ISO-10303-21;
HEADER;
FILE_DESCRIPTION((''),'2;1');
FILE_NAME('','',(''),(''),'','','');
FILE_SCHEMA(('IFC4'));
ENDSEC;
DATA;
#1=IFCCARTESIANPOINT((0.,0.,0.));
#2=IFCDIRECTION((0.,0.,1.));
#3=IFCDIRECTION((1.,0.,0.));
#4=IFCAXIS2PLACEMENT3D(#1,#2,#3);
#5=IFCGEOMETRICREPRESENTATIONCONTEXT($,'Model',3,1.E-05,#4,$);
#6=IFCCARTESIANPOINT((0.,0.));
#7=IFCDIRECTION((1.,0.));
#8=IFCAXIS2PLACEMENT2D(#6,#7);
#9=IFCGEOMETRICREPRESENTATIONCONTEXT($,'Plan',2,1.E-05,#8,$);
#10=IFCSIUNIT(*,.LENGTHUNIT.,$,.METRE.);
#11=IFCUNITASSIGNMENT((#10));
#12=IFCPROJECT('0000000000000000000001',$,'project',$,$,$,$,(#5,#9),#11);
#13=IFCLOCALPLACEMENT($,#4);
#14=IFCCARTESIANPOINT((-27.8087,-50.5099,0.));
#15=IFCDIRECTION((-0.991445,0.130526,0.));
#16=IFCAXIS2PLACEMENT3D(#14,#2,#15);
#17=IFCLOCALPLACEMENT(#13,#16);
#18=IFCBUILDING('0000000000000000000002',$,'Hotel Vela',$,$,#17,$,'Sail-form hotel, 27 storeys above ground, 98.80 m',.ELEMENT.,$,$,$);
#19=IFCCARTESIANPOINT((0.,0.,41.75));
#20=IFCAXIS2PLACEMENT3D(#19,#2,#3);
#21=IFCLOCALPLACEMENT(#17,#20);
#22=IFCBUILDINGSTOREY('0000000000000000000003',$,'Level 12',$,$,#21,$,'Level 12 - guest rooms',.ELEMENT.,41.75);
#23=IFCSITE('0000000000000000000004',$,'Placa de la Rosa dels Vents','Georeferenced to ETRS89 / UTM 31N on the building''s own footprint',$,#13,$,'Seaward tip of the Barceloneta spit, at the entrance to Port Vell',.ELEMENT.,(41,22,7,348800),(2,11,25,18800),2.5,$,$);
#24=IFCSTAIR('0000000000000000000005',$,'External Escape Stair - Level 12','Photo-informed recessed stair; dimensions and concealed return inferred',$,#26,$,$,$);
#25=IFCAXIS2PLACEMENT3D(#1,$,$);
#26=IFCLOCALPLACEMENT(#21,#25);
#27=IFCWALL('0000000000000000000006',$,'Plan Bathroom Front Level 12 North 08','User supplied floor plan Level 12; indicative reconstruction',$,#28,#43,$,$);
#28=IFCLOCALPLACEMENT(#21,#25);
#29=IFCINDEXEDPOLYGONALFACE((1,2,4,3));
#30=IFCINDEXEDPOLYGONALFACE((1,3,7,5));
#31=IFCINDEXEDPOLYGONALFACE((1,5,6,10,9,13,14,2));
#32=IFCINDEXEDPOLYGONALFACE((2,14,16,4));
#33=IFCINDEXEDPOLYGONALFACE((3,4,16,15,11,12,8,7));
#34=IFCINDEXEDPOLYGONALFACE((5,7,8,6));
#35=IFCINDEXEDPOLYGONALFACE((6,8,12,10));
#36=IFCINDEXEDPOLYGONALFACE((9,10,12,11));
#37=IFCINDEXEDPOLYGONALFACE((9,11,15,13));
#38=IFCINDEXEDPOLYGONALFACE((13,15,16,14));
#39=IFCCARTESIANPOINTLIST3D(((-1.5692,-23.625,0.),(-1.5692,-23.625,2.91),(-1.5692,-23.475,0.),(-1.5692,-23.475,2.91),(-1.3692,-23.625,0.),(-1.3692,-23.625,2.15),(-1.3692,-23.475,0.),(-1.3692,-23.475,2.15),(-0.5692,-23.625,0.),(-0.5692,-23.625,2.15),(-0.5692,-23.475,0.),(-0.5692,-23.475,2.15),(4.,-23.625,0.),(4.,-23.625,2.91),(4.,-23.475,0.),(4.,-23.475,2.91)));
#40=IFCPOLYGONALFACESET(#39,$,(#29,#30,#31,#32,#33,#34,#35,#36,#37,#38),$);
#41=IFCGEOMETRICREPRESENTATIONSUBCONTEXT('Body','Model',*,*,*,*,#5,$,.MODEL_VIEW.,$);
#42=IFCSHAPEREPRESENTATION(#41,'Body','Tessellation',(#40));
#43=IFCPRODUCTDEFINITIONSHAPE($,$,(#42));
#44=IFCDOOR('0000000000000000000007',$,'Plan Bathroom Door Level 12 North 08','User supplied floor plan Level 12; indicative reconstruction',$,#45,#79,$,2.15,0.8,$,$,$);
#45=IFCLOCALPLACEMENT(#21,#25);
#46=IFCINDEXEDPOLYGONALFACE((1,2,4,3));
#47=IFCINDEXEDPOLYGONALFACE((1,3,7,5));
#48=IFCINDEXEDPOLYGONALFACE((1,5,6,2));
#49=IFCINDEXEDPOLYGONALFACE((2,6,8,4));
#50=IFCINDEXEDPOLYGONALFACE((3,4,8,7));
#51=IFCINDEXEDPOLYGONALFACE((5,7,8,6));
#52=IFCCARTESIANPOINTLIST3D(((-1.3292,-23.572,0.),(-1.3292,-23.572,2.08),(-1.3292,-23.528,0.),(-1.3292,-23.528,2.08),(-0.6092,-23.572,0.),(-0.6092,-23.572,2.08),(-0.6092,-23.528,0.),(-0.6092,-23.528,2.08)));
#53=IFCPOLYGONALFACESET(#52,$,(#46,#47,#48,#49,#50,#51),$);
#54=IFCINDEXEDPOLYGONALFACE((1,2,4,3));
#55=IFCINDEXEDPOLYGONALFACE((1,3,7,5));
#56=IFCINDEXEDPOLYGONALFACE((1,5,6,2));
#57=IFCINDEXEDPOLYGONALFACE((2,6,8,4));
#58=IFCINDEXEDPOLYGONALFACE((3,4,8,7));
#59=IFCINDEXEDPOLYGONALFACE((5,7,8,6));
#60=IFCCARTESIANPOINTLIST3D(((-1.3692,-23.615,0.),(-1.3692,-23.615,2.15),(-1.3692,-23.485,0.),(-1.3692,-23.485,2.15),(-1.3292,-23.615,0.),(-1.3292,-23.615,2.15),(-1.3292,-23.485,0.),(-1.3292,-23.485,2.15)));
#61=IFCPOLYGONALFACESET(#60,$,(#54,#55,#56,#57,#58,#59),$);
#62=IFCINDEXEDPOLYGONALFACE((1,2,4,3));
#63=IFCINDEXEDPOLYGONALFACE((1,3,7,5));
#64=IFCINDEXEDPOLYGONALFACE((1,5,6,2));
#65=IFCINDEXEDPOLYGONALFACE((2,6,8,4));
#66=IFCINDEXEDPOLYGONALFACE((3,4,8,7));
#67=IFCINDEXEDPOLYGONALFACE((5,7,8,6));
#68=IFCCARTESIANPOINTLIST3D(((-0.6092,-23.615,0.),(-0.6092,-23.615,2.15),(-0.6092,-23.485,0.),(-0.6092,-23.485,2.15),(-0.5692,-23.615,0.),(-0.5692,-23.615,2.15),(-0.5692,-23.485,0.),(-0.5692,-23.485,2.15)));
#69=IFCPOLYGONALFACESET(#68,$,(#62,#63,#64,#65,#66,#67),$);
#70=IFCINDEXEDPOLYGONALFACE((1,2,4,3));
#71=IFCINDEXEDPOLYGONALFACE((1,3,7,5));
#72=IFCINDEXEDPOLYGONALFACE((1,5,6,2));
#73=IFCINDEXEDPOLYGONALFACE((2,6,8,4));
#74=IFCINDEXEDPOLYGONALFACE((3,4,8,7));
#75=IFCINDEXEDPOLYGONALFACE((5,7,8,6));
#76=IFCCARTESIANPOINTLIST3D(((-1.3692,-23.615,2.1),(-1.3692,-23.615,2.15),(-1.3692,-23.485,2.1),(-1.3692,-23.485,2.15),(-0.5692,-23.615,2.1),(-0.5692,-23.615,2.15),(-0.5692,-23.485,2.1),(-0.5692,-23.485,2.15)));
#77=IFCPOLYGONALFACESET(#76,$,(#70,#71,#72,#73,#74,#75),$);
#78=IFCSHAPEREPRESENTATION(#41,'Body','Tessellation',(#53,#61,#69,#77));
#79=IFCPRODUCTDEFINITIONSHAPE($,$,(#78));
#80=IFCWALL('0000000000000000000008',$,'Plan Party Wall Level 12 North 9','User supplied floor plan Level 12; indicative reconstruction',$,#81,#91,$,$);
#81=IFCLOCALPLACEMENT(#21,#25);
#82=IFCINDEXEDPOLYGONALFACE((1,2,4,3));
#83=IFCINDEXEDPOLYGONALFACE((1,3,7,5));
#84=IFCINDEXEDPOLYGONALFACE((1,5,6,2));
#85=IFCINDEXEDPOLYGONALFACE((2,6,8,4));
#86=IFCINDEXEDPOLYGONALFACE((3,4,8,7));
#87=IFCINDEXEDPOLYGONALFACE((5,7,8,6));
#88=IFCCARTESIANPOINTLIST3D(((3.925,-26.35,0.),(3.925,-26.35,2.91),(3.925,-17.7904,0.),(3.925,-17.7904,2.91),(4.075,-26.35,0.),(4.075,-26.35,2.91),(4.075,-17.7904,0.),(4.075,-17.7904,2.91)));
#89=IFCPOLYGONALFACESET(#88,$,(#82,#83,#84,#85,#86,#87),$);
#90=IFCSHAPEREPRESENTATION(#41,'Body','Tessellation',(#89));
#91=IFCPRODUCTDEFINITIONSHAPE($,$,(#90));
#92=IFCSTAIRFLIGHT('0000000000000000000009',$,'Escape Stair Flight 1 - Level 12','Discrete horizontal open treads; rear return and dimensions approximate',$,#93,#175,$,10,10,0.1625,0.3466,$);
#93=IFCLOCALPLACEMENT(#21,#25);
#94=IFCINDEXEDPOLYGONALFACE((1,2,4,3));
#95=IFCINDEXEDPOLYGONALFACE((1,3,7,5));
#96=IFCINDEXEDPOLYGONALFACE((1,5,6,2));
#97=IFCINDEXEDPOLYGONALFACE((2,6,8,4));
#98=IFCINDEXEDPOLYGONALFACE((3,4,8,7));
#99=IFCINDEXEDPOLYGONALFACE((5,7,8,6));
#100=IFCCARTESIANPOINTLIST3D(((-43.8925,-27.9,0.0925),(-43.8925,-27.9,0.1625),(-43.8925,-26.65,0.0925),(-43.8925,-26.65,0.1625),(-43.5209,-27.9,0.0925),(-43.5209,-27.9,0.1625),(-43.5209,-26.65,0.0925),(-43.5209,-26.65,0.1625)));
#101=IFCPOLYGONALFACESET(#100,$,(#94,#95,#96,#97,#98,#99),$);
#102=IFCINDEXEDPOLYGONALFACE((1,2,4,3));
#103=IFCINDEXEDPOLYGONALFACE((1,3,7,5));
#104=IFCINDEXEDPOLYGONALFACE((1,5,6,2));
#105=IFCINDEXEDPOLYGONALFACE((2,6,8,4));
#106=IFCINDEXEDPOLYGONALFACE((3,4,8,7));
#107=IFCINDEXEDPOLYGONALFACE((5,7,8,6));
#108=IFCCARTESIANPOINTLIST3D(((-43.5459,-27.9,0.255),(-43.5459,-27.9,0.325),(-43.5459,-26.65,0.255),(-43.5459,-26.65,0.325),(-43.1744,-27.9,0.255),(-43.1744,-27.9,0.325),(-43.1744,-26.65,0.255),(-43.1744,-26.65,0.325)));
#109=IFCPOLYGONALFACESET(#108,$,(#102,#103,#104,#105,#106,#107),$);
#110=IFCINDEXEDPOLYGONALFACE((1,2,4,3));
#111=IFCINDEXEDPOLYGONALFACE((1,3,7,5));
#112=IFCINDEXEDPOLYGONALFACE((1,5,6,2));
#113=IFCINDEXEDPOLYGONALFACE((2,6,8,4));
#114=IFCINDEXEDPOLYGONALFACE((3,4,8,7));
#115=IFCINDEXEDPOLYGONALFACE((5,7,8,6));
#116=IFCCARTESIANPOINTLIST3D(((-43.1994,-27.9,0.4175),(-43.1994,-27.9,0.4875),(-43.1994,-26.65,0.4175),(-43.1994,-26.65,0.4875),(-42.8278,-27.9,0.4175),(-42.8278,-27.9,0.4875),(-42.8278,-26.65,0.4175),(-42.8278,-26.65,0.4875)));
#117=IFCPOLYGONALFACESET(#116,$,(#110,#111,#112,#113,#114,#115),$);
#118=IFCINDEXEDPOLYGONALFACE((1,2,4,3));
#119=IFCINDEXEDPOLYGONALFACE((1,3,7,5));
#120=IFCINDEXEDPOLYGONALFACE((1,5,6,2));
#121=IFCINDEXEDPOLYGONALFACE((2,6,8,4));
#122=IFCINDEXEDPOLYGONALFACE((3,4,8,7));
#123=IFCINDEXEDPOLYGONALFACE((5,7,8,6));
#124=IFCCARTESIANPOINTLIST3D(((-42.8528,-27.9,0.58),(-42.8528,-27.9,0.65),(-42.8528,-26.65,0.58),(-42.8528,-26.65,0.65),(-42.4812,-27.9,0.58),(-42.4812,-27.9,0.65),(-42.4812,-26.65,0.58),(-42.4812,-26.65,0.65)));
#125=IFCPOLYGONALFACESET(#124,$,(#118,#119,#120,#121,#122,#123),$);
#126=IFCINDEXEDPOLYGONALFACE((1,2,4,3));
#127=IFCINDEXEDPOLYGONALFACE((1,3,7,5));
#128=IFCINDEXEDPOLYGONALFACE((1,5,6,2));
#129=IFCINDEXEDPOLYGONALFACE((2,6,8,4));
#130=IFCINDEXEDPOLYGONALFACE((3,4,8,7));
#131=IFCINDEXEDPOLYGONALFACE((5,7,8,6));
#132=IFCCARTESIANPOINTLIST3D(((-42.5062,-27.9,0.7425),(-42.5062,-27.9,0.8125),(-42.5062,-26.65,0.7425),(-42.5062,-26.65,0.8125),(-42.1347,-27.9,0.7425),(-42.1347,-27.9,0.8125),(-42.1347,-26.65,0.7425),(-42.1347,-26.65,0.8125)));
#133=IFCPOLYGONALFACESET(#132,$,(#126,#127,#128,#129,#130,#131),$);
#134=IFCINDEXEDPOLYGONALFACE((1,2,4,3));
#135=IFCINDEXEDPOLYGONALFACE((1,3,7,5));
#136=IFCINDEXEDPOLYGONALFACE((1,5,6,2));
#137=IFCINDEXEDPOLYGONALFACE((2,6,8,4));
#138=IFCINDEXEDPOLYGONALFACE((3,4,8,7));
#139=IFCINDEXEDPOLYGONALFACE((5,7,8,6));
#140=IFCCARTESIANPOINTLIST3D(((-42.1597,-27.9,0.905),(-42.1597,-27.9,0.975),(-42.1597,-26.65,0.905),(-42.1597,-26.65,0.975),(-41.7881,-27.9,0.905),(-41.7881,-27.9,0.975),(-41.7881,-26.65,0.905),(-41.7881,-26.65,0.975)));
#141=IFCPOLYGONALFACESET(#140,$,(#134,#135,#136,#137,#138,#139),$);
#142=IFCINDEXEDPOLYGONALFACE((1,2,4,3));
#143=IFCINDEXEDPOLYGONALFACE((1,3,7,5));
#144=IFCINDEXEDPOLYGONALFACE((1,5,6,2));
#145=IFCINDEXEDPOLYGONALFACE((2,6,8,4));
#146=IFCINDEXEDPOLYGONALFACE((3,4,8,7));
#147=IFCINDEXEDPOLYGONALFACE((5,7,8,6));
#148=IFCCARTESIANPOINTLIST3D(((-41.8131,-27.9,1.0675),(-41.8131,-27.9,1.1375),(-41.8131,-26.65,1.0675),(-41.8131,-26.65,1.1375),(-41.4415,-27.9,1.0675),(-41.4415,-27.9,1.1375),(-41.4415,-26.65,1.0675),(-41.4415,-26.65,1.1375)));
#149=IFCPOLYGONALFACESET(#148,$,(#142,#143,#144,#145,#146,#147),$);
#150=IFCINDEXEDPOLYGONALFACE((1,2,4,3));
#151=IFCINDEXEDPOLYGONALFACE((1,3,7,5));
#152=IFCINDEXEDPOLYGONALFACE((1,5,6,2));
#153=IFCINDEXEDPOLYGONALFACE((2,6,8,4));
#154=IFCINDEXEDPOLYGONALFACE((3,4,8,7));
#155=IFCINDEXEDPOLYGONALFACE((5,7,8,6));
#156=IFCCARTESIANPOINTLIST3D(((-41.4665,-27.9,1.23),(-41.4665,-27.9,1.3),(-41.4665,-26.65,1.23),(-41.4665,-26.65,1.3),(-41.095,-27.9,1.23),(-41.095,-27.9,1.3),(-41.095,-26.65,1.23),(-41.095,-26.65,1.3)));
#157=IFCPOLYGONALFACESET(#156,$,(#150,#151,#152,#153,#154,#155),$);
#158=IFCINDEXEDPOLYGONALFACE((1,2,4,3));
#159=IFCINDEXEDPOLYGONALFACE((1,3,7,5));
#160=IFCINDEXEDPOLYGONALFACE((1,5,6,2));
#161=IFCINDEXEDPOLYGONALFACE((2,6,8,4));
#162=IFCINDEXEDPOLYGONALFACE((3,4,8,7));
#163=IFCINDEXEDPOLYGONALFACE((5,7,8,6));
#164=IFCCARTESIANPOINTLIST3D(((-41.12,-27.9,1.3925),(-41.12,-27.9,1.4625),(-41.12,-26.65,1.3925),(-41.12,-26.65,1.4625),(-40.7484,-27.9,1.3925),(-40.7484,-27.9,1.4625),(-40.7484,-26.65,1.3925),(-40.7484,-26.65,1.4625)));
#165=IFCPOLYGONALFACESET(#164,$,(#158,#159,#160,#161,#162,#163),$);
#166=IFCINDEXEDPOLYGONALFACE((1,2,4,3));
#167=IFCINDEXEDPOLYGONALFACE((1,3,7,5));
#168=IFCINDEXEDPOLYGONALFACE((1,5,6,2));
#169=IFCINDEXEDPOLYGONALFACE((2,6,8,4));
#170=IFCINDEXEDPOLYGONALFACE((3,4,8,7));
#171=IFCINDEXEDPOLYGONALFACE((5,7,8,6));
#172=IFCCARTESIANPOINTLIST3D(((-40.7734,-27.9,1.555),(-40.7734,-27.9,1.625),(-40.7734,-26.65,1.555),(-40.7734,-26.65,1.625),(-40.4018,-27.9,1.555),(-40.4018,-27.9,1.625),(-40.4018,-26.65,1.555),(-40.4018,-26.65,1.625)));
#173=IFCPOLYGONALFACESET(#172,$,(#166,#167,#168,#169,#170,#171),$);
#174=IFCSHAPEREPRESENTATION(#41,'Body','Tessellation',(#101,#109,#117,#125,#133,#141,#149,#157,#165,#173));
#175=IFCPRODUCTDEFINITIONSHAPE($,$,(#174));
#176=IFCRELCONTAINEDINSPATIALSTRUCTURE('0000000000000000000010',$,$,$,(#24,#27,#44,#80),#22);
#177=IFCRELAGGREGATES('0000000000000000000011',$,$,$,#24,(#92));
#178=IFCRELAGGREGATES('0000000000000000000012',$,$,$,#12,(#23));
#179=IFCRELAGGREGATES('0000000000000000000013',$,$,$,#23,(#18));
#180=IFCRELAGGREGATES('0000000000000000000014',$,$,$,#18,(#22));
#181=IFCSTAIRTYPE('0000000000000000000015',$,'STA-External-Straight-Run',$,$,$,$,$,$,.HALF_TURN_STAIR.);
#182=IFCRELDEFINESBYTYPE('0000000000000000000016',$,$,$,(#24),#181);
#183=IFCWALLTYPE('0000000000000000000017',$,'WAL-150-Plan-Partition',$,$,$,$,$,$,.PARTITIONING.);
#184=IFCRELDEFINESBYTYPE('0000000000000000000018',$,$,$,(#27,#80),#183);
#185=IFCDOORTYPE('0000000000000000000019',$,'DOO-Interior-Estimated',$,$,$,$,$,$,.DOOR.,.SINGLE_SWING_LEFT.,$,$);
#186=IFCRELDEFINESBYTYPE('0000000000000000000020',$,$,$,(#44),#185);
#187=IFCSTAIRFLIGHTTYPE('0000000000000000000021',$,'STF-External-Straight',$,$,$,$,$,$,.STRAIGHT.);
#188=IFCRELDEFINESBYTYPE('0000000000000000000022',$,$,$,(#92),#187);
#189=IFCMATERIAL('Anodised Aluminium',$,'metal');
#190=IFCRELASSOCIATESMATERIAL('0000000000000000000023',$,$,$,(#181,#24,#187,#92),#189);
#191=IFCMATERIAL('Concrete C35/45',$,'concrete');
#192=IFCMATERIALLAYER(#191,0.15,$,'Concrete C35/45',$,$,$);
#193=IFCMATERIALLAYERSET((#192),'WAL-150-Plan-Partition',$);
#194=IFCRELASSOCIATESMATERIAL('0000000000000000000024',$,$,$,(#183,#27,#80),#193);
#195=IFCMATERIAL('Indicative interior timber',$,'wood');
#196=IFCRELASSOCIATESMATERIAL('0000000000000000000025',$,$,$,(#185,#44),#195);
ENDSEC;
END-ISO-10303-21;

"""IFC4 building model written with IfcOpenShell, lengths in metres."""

from ifc_helpers import new_model, si_unit, frame, origin_with_axes, origin_2d_with_axis, place, context, subcontext, project, spatial, line, indexed_curve, outline, extrude, material, layer, layer_set, layer_usage, type_object, element, fill, aggregate, save


model = new_model("IFC4")

# Units and contexts
model_context = context("Model", 3, precision=1e-05, world=origin_with_axes())
plan_context = context("Plan", 2, precision=1e-05, world=origin_2d_with_axis())
body_context = subcontext(model_context, "Body", "Model", "MODEL_VIEW")
ifc_project = project(units=[si_unit("LENGTHUNIT", "METRE")], contexts=[model_context, plan_context])

# Site, building, storey
site_placement = place(None, origin_with_axes())
site = spatial("IfcSite", under=ifc_project, at=site_placement, Name="Placa de la Rosa dels Vents", Description="Georeferenced to ETRS89 / UTM 31N on the building's own footprint", LongName="Seaward tip of the Barceloneta spit, at the entrance to Port Vell", CompositionType="ELEMENT", RefLatitude=(41, 22, 7, 348800), RefLongitude=(2, 11, 25, 18800), RefElevation=2.5)
building_placement = place(site_placement, frame((-27.8087, -50.5099, 0.0), z_axis=(0.0, 0.0, 1.0), x_axis=(-0.991445, 0.130526, 0.0)))
building = spatial("IfcBuilding", under=site, at=building_placement, Name="Hotel Vela", LongName="Sail-form hotel, 27 storeys above ground, 98.80 m", CompositionType="ELEMENT")
storey_placement = place(building_placement, frame((0.0, 0.0, 41.75), z_axis=(0.0, 0.0, 1.0), x_axis=(1.0, 0.0, 0.0)))
storey = spatial("IfcBuildingStorey", under=building, at=storey_placement, Name="Level 12", LongName="Level 12 - guest rooms", CompositionType="ELEMENT", Elevation=41.75)

# Stair
ifc_material_1 = material(Name="Anodised Aluminium", Category="metal")
stair_type = type_object("IfcStairType", Name="STA-External-Straight-Run", PredefinedType="HALF_TURN_STAIR", material=ifc_material_1)
stair_placement = place(storey_placement, frame((0.0, 0.0, -41.75), z_axis=(0.0, 0.0, 1.0), x_axis=(1.0, 0.0, 0.0)))
stair = element("IfcStair", 1, at=stair_placement, inside=storey, type_object=stair_type, material=ifc_material_1, Name="External Escape Stair - Level 12", Description="Photo-informed recessed stair; dimensions and concealed return inferred")

# Shared definitions
ifc_material_2 = material(Name="Concrete C35/45", Category="concrete")
ifc_layer = layer(ifc_material_2, 0.15, Name="Concrete C35/45")
ifc_layer_set = layer_set([ifc_layer], Name="WAL-150-Plan-Partition")
wall_type = type_object("IfcWallType", Name="WAL-150-Plan-Partition", PredefinedType="PARTITIONING", material=ifc_layer_set)
ifc_material_3 = material(Name="Indicative interior timber", Category="wood")
door_type = type_object("IfcDoorType", Name="DOO-Interior-Estimated", OperationType="SINGLE_SWING_LEFT", PredefinedType="DOOR", material=ifc_material_3)

# Wall, opening, door
ifc_layer_usage_1 = layer_usage(ifc_layer_set, "AXIS2", "POSITIVE", 0.0)
wall_1_placement = place(storey_placement, frame((-1.5692, -23.625, 0.0), z_axis=(0.0, 0.0, 1.0), x_axis=(1.0, 0.0, 0.0)))
wall_1 = element("IfcWall", 2, at=wall_1_placement, inside=storey, type_object=wall_type, material=ifc_layer_usage_1, Name="Plan Bathroom Front Level 12 North 08", Description="User supplied floor plan Level 12; indicative reconstruction", context=body_context, shape_type="SweptSolid", body=[
    extrude(outline(indexed_curve([(0.0, 0.0), (5.5692, 0.0), (5.5692, 0.15), (0.0, 0.15)], segments=[line(1, 2, 3, 4, 1)])), origin_with_axes(), (0.0, 0.0, 1.0), 2.91),
])
opening_1_placement = place(wall_1_placement, frame((0.2, -0.085, 0.0), z_axis=(0.0, 0.0, 1.0), x_axis=(1.0, 0.0, 0.0)))
opening_1 = element("IfcOpeningElement", 3, at=opening_1_placement, cuts=wall_1, PredefinedType="OPENING", context=body_context, shape_type="SweptSolid", body=[
    extrude(outline(indexed_curve([(0.0, 0.0), (0.8, 0.0), (0.8, 0.32), (0.0, 0.32)], segments=[line(1, 2, 3, 4, 1)])), origin_with_axes(), (0.0, 0.0, 1.0), 2.15),
])
door_1_placement = place(storey_placement, frame((0.0, 0.0, -41.75), z_axis=(0.0, 0.0, 1.0), x_axis=(1.0, 0.0, 0.0)))
door_1 = element("IfcDoor", 4, at=door_1_placement, inside=storey, type_object=door_type, material=ifc_material_3, Name="Plan Bathroom Door Level 12 North 08", Description="User supplied floor plan Level 12; indicative reconstruction", OverallHeight=2.15, OverallWidth=0.8, context=body_context, shape_type="SweptSolid", body=[
    extrude(outline(indexed_curve([(0.0, 0.0), (0.72, 0.0), (0.72, 0.044), (0.0, 0.044)], segments=[line(1, 2, 3, 4, 1)])), frame((-1.3292, -23.572, 41.75), z_axis=(0.0, 0.0, 1.0), x_axis=(1.0, 0.0, 0.0)), (0.0, 0.0, 1.0), 2.08),
    extrude(outline(indexed_curve([(0.0, 0.0), (0.04, 0.0), (0.04, 0.13), (0.0, 0.13)], segments=[line(1, 2, 3, 4, 1)])), frame((-1.3692, -23.615, 41.75), z_axis=(0.0, 0.0, 1.0), x_axis=(1.0, 0.0, 0.0)), (0.0, 0.0, 1.0), 2.15),
    extrude(outline(indexed_curve([(0.0, 0.0), (0.04, 0.0), (0.04, 0.13), (0.0, 0.13)], segments=[line(1, 2, 3, 4, 1)])), frame((-0.6092, -23.615, 41.75), z_axis=(0.0, 0.0, 1.0), x_axis=(1.0, 0.0, 0.0)), (0.0, 0.0, 1.0), 2.15),
    extrude(outline(indexed_curve([(0.0, 0.0), (0.8, 0.0), (0.8, 0.13), (0.0, 0.13)], segments=[line(1, 2, 3, 4, 1)])), frame((-1.3692, -23.615, 43.85), z_axis=(0.0, 0.0, 1.0), x_axis=(1.0, 0.0, 0.0)), (0.0, 0.0, 1.0), 0.05),
])
fill(opening_1, door_1)

# Wall
ifc_layer_usage_2 = layer_usage(ifc_layer_set, "AXIS2", "POSITIVE", 0.0)
wall_2_placement = place(storey_placement, frame((3.925, -26.35, 0.0), z_axis=(0.0, 0.0, 1.0), x_axis=(1.0, 0.0, 0.0)))
element("IfcWall", 5, at=wall_2_placement, inside=storey, type_object=wall_type, material=ifc_layer_usage_2, Name="Plan Party Wall Level 12 North 9", Description="User supplied floor plan Level 12; indicative reconstruction", context=body_context, shape_type="SweptSolid", body=[
    extrude(outline(indexed_curve([(0.0, 0.0), (0.15, 0.0), (0.15, 8.5596), (0.0, 8.5596)], segments=[line(1, 2, 3, 4, 1)])), origin_with_axes(), (0.0, 0.0, 1.0), 2.91),
])

# Stair flight
stair_flight_type = type_object("IfcStairFlightType", Name="STF-External-Straight", PredefinedType="STRAIGHT", material=ifc_material_1)
stair_flight_1_placement = place(stair_placement, origin_with_axes())
stair_flight_1 = element("IfcStairFlight", 6, at=stair_flight_1_placement, type_object=stair_flight_type, material=ifc_material_1, Name="Escape Stair Flight 1 - Level 12", Description="Discrete horizontal open treads; rear return and dimensions approximate", NumberOfRisers=10, NumberOfTreads=10, RiserHeight=0.1625, TreadLength=0.3466, context=body_context, shape_type="SweptSolid", body=[
    extrude(outline(indexed_curve([(0.0, 0.0), (0.3716, 0.0), (0.3716, 1.25), (0.0, 1.25)], segments=[line(1, 2, 3, 4, 1)])), frame((-43.8925, -27.9, 41.8425), z_axis=(0.0, 0.0, 1.0), x_axis=(1.0, 0.0, 0.0)), (0.0, 0.0, 1.0), 0.07),
    extrude(outline(indexed_curve([(0.0, 0.0), (0.3716, 0.0), (0.3716, 1.25), (0.0, 1.25)], segments=[line(1, 2, 3, 4, 1)])), frame((-43.5459, -27.9, 42.005), z_axis=(0.0, 0.0, 1.0), x_axis=(1.0, 0.0, 0.0)), (0.0, 0.0, 1.0), 0.07),
    extrude(outline(indexed_curve([(0.0, 0.0), (0.3716, 0.0), (0.3716, 1.25), (0.0, 1.25)], segments=[line(1, 2, 3, 4, 1)])), frame((-43.1994, -27.9, 42.1675), z_axis=(0.0, 0.0, 1.0), x_axis=(1.0, 0.0, 0.0)), (0.0, 0.0, 1.0), 0.07),
    extrude(outline(indexed_curve([(0.0, 0.0), (0.3716, 0.0), (0.3716, 1.25), (0.0, 1.25)], segments=[line(1, 2, 3, 4, 1)])), frame((-42.8528, -27.9, 42.33), z_axis=(0.0, 0.0, 1.0), x_axis=(1.0, 0.0, 0.0)), (0.0, 0.0, 1.0), 0.07),
    extrude(outline(indexed_curve([(0.0, 0.0), (0.3716, 0.0), (0.3716, 1.25), (0.0, 1.25)], segments=[line(1, 2, 3, 4, 1)])), frame((-42.5062, -27.9, 42.4925), z_axis=(0.0, 0.0, 1.0), x_axis=(1.0, 0.0, 0.0)), (0.0, 0.0, 1.0), 0.07),
    extrude(outline(indexed_curve([(0.0, 0.0), (0.3716, 0.0), (0.3716, 1.25), (0.0, 1.25)], segments=[line(1, 2, 3, 4, 1)])), frame((-42.1597, -27.9, 42.655), z_axis=(0.0, 0.0, 1.0), x_axis=(1.0, 0.0, 0.0)), (0.0, 0.0, 1.0), 0.07),
    extrude(outline(indexed_curve([(0.0, 0.0), (0.3716, 0.0), (0.3716, 1.25), (0.0, 1.25)], segments=[line(1, 2, 3, 4, 1)])), frame((-41.8131, -27.9, 42.8175), z_axis=(0.0, 0.0, 1.0), x_axis=(1.0, 0.0, 0.0)), (0.0, 0.0, 1.0), 0.07),
    extrude(outline(indexed_curve([(0.0, 0.0), (0.3716, 0.0), (0.3716, 1.25), (0.0, 1.25)], segments=[line(1, 2, 3, 4, 1)])), frame((-41.4665, -27.9, 42.98), z_axis=(0.0, 0.0, 1.0), x_axis=(1.0, 0.0, 0.0)), (0.0, 0.0, 1.0), 0.07),
    extrude(outline(indexed_curve([(0.0, 0.0), (0.3716, 0.0), (0.3716, 1.25), (0.0, 1.25)], segments=[line(1, 2, 3, 4, 1)])), frame((-41.12, -27.9, 43.1425), z_axis=(0.0, 0.0, 1.0), x_axis=(1.0, 0.0, 0.0)), (0.0, 0.0, 1.0), 0.07),
    extrude(outline(indexed_curve([(0.0, 0.0), (0.3716, 0.0), (0.3716, 1.25), (0.0, 1.25)], segments=[line(1, 2, 3, 4, 1)])), frame((-40.7734, -27.9, 43.305), z_axis=(0.0, 0.0, 1.0), x_axis=(1.0, 0.0, 0.0)), (0.0, 0.0, 1.0), 0.07),
])

aggregate(stair, [stair_flight_1])

save(model, "model.ifc")
